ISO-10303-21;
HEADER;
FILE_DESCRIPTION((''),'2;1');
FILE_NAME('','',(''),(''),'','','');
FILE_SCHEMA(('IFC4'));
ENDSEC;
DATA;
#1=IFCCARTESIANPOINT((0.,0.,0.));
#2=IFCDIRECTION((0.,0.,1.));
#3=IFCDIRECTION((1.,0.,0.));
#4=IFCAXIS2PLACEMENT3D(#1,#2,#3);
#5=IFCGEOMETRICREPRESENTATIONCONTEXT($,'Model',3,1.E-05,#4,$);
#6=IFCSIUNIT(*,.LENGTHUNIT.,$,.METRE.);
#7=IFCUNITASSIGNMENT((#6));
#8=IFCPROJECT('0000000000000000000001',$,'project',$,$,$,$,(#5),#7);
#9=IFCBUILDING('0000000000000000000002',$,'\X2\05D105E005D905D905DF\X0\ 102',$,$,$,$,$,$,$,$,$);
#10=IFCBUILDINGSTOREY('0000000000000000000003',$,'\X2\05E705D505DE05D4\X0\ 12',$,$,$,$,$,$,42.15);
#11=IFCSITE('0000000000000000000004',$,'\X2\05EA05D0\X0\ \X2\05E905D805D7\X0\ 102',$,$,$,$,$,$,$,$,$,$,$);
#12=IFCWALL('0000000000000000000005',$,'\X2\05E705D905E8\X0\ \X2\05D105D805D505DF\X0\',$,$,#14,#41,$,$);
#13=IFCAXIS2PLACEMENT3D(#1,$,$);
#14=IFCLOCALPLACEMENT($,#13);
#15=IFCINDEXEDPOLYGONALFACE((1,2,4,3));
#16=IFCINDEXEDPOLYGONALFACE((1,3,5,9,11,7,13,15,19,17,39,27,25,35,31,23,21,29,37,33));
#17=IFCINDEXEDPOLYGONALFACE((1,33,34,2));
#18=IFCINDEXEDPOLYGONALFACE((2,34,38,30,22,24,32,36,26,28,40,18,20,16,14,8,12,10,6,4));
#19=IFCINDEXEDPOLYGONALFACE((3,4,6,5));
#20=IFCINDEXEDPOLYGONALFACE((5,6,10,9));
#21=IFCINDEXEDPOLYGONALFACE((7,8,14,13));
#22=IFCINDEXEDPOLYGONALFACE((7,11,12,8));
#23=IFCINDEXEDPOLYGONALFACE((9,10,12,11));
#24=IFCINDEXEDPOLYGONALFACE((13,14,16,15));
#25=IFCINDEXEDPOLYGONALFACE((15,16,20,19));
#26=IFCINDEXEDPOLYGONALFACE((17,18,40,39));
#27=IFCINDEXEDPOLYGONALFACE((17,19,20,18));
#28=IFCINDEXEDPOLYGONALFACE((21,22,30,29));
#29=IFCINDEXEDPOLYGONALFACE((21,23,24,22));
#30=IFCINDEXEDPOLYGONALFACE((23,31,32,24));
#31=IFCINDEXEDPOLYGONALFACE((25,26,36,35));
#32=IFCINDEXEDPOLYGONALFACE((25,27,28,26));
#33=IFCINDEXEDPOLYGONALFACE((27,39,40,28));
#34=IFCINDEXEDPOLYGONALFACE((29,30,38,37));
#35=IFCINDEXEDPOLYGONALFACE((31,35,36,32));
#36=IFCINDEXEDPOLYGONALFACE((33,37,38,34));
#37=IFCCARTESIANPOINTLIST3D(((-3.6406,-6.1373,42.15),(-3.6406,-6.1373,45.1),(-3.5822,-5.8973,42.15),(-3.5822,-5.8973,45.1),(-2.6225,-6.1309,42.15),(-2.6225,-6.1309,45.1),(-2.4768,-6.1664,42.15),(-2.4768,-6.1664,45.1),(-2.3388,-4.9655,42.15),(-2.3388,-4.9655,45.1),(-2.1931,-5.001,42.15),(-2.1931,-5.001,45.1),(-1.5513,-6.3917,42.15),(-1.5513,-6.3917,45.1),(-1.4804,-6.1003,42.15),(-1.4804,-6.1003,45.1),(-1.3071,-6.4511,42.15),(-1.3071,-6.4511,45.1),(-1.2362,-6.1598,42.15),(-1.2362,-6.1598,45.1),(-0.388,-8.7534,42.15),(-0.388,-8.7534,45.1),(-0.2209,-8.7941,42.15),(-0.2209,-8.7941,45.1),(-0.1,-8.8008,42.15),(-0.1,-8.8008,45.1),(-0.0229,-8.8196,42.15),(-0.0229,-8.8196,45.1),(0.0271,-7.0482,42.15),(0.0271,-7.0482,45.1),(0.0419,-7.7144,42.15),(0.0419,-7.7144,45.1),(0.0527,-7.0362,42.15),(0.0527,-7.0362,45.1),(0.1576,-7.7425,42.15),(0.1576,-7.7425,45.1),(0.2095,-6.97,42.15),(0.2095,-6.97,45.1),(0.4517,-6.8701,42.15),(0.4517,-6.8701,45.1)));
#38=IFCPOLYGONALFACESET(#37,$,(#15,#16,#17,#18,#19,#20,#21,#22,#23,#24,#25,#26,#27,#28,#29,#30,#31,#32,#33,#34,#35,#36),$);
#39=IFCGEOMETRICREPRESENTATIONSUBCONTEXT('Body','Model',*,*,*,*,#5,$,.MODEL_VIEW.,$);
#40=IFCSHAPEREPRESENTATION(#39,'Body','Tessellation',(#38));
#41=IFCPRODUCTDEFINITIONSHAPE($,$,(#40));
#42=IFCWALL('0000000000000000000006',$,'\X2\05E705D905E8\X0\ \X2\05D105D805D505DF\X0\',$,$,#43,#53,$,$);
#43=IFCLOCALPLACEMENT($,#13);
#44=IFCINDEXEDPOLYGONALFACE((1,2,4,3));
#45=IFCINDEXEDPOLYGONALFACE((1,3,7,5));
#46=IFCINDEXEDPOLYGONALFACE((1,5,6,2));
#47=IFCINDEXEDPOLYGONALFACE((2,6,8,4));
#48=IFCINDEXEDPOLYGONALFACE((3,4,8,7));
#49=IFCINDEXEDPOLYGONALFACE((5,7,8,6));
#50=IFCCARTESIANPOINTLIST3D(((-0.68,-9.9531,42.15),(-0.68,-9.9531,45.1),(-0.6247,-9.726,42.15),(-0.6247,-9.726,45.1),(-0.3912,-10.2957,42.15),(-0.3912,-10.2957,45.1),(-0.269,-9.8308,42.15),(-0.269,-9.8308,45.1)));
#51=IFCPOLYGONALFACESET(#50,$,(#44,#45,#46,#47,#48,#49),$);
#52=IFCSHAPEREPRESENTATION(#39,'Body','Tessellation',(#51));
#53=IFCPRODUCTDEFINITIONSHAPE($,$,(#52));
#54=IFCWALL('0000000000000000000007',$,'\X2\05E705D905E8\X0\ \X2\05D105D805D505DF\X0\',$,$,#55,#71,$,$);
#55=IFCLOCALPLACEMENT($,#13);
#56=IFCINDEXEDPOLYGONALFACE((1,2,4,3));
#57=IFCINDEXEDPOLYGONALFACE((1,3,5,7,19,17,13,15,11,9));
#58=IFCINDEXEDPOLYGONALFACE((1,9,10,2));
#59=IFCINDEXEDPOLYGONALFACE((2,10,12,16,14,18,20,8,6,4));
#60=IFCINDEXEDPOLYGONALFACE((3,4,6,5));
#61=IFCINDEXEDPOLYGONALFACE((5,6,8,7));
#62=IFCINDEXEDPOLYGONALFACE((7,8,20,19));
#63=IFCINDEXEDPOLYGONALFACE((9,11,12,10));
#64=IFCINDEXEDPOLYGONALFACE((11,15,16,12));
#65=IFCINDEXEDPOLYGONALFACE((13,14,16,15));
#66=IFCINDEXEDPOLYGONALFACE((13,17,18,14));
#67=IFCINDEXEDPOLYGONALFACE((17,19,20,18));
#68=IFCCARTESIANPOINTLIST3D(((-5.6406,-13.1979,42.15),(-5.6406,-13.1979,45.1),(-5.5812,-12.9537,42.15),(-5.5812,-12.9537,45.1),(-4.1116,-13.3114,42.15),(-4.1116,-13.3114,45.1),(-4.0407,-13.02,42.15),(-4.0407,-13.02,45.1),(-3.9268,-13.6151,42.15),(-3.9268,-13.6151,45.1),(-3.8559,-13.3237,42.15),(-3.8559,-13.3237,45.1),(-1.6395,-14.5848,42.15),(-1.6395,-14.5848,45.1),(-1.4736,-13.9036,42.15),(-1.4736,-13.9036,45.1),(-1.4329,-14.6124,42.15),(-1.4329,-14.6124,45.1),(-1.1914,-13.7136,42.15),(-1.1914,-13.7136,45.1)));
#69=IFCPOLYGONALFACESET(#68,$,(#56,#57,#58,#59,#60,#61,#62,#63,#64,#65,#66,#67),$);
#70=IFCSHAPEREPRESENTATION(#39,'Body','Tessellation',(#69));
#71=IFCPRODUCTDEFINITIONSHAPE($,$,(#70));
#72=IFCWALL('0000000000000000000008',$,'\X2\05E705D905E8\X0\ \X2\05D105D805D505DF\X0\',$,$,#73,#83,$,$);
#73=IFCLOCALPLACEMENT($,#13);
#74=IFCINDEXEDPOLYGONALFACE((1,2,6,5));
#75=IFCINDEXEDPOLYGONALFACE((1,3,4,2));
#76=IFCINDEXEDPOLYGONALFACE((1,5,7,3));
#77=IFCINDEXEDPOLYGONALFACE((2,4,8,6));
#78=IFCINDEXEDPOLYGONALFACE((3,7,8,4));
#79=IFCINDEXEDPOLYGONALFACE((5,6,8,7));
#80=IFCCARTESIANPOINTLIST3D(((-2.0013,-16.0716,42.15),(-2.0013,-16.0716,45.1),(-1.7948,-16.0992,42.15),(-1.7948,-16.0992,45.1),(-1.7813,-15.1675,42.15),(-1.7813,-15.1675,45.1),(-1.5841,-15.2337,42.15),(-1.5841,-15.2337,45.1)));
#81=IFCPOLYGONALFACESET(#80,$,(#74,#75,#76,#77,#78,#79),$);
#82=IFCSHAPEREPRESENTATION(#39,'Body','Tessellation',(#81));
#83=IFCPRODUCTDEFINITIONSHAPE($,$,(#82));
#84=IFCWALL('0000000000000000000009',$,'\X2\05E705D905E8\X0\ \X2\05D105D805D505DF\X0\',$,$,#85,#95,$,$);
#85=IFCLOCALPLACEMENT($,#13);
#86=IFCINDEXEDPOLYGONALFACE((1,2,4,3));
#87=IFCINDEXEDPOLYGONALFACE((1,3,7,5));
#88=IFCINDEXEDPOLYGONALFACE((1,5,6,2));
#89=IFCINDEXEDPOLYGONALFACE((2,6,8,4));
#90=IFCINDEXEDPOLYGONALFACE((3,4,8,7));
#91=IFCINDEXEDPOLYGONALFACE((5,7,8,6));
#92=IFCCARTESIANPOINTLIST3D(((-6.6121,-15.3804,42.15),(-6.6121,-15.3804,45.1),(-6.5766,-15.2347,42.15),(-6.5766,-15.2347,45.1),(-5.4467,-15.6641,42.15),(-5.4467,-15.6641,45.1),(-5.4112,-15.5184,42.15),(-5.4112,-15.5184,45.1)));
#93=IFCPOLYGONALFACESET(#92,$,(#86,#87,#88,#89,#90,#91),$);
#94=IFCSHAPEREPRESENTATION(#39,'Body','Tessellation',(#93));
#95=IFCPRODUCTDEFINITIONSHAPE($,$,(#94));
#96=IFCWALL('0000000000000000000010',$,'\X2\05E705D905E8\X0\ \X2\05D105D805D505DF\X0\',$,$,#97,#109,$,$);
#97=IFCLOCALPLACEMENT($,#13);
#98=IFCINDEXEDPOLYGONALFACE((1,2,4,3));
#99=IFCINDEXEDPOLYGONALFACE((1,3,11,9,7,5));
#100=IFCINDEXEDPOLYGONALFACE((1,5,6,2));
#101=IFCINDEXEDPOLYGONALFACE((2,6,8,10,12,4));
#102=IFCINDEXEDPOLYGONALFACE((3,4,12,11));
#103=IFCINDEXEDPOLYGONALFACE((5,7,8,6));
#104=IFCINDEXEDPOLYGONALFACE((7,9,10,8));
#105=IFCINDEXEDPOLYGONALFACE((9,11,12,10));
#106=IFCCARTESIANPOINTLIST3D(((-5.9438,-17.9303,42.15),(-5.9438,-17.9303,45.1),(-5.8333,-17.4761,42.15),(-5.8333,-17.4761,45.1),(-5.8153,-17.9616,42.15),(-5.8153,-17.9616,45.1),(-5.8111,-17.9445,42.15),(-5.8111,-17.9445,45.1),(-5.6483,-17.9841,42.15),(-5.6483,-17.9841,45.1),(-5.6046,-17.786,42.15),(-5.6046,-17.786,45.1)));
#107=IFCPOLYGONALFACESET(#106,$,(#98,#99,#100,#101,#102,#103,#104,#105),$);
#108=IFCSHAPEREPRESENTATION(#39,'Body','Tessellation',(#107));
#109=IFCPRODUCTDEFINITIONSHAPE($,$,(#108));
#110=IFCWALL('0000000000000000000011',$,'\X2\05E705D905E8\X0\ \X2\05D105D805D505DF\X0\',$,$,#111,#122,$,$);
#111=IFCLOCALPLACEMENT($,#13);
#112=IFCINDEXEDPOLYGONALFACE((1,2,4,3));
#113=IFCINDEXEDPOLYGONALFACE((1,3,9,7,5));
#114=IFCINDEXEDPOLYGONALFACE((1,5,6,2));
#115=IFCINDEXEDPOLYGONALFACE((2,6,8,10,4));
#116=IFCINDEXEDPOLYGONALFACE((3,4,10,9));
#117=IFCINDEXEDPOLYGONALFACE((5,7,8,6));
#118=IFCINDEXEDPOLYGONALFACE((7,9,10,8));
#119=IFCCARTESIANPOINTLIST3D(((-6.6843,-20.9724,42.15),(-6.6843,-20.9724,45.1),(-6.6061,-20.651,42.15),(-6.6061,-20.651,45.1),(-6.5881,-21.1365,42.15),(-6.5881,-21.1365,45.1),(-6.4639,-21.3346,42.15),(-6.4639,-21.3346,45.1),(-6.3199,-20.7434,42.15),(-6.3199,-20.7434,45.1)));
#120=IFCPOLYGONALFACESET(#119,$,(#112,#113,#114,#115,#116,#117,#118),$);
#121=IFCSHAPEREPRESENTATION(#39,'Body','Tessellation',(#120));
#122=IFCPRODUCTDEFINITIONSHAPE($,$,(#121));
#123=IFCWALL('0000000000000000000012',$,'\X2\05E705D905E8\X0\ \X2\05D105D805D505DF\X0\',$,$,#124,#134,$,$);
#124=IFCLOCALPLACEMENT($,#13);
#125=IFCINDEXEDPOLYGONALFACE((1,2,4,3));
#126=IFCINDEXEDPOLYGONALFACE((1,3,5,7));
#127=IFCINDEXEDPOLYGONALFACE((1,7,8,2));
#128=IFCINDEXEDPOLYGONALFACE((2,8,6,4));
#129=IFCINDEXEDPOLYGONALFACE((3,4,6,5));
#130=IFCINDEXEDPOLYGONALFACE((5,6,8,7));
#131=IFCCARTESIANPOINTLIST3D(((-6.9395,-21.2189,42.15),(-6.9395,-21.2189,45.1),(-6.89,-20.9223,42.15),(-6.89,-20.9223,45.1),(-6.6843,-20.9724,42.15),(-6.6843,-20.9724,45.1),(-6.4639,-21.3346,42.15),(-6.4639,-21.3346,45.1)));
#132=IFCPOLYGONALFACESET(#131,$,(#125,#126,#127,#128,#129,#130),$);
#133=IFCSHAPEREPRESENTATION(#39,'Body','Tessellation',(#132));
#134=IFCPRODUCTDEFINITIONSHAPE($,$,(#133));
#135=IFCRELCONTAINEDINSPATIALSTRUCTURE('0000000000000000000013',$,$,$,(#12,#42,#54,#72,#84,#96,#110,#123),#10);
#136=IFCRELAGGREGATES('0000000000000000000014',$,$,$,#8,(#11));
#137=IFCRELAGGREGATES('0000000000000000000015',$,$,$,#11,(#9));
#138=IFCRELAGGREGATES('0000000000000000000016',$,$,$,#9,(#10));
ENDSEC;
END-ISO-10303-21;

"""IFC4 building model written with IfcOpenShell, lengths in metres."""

from ifc_helpers import new_model, si_unit, frame, origin_with_axes, context, subcontext, project, spatial, polyline, outline, extrude, element, save


model = new_model("IFC4")

# Units and contexts
model_context = context("Model", 3, precision=1e-05, world=origin_with_axes())
body_context = subcontext(model_context, "Body", "Model", "MODEL_VIEW")
ifc_project = project(units=[si_unit("LENGTHUNIT", "METRE")], contexts=[model_context])

# Site, building, storey
site = spatial("IfcSite", under=ifc_project, Name="תא שטח 102")
building = spatial("IfcBuilding", under=site, Name="בניין 102")
storey = spatial("IfcBuildingStorey", under=building, Name="קומה 12", Elevation=42.15)

# Walls
element("IfcWall", 1, inside=storey, Name="קיר בטון", context=body_context, shape_type="SweptSolid", body=[
    extrude(outline(polyline([(-2.3388, -4.9655), (-2.6225, -6.1309), (-3.5822, -5.8973), (-3.6406, -6.1373), (0.0527, -7.0362), (0.2095, -6.97), (0.0271, -7.0482), (-0.388, -8.7534), (-0.2209, -8.7941), (0.0419, -7.7144), (0.1576, -7.7425), (-0.1, -8.8008), (-0.0229, -8.8196), (0.4517, -6.8701), (-1.3071, -6.4511), (-1.2362, -6.1598), (-1.4804, -6.1003), (-1.5513, -6.3917), (-2.4768, -6.1664), (-2.1931, -5.001), (-2.3388, -4.9655)])), frame((0.0, 0.0, 42.15)), (0.0, 0.0, 1.0), 2.95),
])
element("IfcWall", 2, inside=storey, Name="קיר בטון", context=body_context, shape_type="SweptSolid", body=[
    extrude(outline(polyline([(-0.3912, -10.2957), (-0.269, -9.8308), (-0.6247, -9.726), (-0.68, -9.9531), (-0.3912, -10.2957)])), frame((0.0, 0.0, 42.15)), (0.0, 0.0, 1.0), 2.95),
])
element("IfcWall", 3, inside=storey, Name="קיר בטון", context=body_context, shape_type="SweptSolid", body=[
    extrude(outline(polyline([(-5.6406, -13.1979), (-3.9268, -13.6151), (-3.8559, -13.3237), (-1.4736, -13.9036), (-1.6395, -14.5848), (-1.4329, -14.6124), (-1.1914, -13.7136), (-4.0407, -13.02), (-4.1116, -13.3114), (-5.5812, -12.9537), (-5.6406, -13.1979)])), frame((0.0, 0.0, 42.15)), (0.0, 0.0, 1.0), 2.95),
])
element("IfcWall", 4, inside=storey, Name="קיר בטון", context=body_context, shape_type="SweptSolid", body=[
    extrude(outline(polyline([(-2.0013, -16.0716), (-1.7948, -16.0992), (-1.5841, -15.2337), (-1.7813, -15.1675), (-2.0013, -16.0716)])), frame((0.0, 0.0, 42.15)), (0.0, 0.0, 1.0), 2.95),
])
element("IfcWall", 5, inside=storey, Name="קיר בטון", context=body_context, shape_type="SweptSolid", body=[
    extrude(outline(polyline([(-6.5766, -15.2347), (-6.6121, -15.3804), (-5.4467, -15.6641), (-5.4112, -15.5184), (-6.5766, -15.2347)])), frame((0.0, 0.0, 42.15)), (0.0, 0.0, 1.0), 2.95),
])
element("IfcWall", 6, inside=storey, Name="קיר בטון", context=body_context, shape_type="SweptSolid", body=[
    extrude(outline(polyline([(-5.8153, -17.9616), (-5.8111, -17.9445), (-5.6483, -17.9841), (-5.6046, -17.786), (-5.8333, -17.4761), (-5.9438, -17.9303), (-5.8153, -17.9616)])), frame((0.0, 0.0, 42.15)), (0.0, 0.0, 1.0), 2.95),
])
element("IfcWall", 7, inside=storey, Name="קיר בטון", context=body_context, shape_type="SweptSolid", body=[
    extrude(outline(polyline([(-6.3199, -20.7434), (-6.6061, -20.651), (-6.6843, -20.9724), (-6.5881, -21.1365), (-6.4639, -21.3346), (-6.3199, -20.7434)])), frame((0.0, 0.0, 42.15)), (0.0, 0.0, 1.0), 2.95),
])
element("IfcWall", 8, inside=storey, Name="קיר בטון", context=body_context, shape_type="SweptSolid", body=[
    extrude(outline(polyline([(-6.6843, -20.9724), (-6.89, -20.9223), (-6.9395, -21.2189), (-6.4639, -21.3346), (-6.6843, -20.9724)])), frame((0.0, 0.0, 42.15)), (0.0, 0.0, 1.0), 2.95),
])

save(model, "model.ifc")
